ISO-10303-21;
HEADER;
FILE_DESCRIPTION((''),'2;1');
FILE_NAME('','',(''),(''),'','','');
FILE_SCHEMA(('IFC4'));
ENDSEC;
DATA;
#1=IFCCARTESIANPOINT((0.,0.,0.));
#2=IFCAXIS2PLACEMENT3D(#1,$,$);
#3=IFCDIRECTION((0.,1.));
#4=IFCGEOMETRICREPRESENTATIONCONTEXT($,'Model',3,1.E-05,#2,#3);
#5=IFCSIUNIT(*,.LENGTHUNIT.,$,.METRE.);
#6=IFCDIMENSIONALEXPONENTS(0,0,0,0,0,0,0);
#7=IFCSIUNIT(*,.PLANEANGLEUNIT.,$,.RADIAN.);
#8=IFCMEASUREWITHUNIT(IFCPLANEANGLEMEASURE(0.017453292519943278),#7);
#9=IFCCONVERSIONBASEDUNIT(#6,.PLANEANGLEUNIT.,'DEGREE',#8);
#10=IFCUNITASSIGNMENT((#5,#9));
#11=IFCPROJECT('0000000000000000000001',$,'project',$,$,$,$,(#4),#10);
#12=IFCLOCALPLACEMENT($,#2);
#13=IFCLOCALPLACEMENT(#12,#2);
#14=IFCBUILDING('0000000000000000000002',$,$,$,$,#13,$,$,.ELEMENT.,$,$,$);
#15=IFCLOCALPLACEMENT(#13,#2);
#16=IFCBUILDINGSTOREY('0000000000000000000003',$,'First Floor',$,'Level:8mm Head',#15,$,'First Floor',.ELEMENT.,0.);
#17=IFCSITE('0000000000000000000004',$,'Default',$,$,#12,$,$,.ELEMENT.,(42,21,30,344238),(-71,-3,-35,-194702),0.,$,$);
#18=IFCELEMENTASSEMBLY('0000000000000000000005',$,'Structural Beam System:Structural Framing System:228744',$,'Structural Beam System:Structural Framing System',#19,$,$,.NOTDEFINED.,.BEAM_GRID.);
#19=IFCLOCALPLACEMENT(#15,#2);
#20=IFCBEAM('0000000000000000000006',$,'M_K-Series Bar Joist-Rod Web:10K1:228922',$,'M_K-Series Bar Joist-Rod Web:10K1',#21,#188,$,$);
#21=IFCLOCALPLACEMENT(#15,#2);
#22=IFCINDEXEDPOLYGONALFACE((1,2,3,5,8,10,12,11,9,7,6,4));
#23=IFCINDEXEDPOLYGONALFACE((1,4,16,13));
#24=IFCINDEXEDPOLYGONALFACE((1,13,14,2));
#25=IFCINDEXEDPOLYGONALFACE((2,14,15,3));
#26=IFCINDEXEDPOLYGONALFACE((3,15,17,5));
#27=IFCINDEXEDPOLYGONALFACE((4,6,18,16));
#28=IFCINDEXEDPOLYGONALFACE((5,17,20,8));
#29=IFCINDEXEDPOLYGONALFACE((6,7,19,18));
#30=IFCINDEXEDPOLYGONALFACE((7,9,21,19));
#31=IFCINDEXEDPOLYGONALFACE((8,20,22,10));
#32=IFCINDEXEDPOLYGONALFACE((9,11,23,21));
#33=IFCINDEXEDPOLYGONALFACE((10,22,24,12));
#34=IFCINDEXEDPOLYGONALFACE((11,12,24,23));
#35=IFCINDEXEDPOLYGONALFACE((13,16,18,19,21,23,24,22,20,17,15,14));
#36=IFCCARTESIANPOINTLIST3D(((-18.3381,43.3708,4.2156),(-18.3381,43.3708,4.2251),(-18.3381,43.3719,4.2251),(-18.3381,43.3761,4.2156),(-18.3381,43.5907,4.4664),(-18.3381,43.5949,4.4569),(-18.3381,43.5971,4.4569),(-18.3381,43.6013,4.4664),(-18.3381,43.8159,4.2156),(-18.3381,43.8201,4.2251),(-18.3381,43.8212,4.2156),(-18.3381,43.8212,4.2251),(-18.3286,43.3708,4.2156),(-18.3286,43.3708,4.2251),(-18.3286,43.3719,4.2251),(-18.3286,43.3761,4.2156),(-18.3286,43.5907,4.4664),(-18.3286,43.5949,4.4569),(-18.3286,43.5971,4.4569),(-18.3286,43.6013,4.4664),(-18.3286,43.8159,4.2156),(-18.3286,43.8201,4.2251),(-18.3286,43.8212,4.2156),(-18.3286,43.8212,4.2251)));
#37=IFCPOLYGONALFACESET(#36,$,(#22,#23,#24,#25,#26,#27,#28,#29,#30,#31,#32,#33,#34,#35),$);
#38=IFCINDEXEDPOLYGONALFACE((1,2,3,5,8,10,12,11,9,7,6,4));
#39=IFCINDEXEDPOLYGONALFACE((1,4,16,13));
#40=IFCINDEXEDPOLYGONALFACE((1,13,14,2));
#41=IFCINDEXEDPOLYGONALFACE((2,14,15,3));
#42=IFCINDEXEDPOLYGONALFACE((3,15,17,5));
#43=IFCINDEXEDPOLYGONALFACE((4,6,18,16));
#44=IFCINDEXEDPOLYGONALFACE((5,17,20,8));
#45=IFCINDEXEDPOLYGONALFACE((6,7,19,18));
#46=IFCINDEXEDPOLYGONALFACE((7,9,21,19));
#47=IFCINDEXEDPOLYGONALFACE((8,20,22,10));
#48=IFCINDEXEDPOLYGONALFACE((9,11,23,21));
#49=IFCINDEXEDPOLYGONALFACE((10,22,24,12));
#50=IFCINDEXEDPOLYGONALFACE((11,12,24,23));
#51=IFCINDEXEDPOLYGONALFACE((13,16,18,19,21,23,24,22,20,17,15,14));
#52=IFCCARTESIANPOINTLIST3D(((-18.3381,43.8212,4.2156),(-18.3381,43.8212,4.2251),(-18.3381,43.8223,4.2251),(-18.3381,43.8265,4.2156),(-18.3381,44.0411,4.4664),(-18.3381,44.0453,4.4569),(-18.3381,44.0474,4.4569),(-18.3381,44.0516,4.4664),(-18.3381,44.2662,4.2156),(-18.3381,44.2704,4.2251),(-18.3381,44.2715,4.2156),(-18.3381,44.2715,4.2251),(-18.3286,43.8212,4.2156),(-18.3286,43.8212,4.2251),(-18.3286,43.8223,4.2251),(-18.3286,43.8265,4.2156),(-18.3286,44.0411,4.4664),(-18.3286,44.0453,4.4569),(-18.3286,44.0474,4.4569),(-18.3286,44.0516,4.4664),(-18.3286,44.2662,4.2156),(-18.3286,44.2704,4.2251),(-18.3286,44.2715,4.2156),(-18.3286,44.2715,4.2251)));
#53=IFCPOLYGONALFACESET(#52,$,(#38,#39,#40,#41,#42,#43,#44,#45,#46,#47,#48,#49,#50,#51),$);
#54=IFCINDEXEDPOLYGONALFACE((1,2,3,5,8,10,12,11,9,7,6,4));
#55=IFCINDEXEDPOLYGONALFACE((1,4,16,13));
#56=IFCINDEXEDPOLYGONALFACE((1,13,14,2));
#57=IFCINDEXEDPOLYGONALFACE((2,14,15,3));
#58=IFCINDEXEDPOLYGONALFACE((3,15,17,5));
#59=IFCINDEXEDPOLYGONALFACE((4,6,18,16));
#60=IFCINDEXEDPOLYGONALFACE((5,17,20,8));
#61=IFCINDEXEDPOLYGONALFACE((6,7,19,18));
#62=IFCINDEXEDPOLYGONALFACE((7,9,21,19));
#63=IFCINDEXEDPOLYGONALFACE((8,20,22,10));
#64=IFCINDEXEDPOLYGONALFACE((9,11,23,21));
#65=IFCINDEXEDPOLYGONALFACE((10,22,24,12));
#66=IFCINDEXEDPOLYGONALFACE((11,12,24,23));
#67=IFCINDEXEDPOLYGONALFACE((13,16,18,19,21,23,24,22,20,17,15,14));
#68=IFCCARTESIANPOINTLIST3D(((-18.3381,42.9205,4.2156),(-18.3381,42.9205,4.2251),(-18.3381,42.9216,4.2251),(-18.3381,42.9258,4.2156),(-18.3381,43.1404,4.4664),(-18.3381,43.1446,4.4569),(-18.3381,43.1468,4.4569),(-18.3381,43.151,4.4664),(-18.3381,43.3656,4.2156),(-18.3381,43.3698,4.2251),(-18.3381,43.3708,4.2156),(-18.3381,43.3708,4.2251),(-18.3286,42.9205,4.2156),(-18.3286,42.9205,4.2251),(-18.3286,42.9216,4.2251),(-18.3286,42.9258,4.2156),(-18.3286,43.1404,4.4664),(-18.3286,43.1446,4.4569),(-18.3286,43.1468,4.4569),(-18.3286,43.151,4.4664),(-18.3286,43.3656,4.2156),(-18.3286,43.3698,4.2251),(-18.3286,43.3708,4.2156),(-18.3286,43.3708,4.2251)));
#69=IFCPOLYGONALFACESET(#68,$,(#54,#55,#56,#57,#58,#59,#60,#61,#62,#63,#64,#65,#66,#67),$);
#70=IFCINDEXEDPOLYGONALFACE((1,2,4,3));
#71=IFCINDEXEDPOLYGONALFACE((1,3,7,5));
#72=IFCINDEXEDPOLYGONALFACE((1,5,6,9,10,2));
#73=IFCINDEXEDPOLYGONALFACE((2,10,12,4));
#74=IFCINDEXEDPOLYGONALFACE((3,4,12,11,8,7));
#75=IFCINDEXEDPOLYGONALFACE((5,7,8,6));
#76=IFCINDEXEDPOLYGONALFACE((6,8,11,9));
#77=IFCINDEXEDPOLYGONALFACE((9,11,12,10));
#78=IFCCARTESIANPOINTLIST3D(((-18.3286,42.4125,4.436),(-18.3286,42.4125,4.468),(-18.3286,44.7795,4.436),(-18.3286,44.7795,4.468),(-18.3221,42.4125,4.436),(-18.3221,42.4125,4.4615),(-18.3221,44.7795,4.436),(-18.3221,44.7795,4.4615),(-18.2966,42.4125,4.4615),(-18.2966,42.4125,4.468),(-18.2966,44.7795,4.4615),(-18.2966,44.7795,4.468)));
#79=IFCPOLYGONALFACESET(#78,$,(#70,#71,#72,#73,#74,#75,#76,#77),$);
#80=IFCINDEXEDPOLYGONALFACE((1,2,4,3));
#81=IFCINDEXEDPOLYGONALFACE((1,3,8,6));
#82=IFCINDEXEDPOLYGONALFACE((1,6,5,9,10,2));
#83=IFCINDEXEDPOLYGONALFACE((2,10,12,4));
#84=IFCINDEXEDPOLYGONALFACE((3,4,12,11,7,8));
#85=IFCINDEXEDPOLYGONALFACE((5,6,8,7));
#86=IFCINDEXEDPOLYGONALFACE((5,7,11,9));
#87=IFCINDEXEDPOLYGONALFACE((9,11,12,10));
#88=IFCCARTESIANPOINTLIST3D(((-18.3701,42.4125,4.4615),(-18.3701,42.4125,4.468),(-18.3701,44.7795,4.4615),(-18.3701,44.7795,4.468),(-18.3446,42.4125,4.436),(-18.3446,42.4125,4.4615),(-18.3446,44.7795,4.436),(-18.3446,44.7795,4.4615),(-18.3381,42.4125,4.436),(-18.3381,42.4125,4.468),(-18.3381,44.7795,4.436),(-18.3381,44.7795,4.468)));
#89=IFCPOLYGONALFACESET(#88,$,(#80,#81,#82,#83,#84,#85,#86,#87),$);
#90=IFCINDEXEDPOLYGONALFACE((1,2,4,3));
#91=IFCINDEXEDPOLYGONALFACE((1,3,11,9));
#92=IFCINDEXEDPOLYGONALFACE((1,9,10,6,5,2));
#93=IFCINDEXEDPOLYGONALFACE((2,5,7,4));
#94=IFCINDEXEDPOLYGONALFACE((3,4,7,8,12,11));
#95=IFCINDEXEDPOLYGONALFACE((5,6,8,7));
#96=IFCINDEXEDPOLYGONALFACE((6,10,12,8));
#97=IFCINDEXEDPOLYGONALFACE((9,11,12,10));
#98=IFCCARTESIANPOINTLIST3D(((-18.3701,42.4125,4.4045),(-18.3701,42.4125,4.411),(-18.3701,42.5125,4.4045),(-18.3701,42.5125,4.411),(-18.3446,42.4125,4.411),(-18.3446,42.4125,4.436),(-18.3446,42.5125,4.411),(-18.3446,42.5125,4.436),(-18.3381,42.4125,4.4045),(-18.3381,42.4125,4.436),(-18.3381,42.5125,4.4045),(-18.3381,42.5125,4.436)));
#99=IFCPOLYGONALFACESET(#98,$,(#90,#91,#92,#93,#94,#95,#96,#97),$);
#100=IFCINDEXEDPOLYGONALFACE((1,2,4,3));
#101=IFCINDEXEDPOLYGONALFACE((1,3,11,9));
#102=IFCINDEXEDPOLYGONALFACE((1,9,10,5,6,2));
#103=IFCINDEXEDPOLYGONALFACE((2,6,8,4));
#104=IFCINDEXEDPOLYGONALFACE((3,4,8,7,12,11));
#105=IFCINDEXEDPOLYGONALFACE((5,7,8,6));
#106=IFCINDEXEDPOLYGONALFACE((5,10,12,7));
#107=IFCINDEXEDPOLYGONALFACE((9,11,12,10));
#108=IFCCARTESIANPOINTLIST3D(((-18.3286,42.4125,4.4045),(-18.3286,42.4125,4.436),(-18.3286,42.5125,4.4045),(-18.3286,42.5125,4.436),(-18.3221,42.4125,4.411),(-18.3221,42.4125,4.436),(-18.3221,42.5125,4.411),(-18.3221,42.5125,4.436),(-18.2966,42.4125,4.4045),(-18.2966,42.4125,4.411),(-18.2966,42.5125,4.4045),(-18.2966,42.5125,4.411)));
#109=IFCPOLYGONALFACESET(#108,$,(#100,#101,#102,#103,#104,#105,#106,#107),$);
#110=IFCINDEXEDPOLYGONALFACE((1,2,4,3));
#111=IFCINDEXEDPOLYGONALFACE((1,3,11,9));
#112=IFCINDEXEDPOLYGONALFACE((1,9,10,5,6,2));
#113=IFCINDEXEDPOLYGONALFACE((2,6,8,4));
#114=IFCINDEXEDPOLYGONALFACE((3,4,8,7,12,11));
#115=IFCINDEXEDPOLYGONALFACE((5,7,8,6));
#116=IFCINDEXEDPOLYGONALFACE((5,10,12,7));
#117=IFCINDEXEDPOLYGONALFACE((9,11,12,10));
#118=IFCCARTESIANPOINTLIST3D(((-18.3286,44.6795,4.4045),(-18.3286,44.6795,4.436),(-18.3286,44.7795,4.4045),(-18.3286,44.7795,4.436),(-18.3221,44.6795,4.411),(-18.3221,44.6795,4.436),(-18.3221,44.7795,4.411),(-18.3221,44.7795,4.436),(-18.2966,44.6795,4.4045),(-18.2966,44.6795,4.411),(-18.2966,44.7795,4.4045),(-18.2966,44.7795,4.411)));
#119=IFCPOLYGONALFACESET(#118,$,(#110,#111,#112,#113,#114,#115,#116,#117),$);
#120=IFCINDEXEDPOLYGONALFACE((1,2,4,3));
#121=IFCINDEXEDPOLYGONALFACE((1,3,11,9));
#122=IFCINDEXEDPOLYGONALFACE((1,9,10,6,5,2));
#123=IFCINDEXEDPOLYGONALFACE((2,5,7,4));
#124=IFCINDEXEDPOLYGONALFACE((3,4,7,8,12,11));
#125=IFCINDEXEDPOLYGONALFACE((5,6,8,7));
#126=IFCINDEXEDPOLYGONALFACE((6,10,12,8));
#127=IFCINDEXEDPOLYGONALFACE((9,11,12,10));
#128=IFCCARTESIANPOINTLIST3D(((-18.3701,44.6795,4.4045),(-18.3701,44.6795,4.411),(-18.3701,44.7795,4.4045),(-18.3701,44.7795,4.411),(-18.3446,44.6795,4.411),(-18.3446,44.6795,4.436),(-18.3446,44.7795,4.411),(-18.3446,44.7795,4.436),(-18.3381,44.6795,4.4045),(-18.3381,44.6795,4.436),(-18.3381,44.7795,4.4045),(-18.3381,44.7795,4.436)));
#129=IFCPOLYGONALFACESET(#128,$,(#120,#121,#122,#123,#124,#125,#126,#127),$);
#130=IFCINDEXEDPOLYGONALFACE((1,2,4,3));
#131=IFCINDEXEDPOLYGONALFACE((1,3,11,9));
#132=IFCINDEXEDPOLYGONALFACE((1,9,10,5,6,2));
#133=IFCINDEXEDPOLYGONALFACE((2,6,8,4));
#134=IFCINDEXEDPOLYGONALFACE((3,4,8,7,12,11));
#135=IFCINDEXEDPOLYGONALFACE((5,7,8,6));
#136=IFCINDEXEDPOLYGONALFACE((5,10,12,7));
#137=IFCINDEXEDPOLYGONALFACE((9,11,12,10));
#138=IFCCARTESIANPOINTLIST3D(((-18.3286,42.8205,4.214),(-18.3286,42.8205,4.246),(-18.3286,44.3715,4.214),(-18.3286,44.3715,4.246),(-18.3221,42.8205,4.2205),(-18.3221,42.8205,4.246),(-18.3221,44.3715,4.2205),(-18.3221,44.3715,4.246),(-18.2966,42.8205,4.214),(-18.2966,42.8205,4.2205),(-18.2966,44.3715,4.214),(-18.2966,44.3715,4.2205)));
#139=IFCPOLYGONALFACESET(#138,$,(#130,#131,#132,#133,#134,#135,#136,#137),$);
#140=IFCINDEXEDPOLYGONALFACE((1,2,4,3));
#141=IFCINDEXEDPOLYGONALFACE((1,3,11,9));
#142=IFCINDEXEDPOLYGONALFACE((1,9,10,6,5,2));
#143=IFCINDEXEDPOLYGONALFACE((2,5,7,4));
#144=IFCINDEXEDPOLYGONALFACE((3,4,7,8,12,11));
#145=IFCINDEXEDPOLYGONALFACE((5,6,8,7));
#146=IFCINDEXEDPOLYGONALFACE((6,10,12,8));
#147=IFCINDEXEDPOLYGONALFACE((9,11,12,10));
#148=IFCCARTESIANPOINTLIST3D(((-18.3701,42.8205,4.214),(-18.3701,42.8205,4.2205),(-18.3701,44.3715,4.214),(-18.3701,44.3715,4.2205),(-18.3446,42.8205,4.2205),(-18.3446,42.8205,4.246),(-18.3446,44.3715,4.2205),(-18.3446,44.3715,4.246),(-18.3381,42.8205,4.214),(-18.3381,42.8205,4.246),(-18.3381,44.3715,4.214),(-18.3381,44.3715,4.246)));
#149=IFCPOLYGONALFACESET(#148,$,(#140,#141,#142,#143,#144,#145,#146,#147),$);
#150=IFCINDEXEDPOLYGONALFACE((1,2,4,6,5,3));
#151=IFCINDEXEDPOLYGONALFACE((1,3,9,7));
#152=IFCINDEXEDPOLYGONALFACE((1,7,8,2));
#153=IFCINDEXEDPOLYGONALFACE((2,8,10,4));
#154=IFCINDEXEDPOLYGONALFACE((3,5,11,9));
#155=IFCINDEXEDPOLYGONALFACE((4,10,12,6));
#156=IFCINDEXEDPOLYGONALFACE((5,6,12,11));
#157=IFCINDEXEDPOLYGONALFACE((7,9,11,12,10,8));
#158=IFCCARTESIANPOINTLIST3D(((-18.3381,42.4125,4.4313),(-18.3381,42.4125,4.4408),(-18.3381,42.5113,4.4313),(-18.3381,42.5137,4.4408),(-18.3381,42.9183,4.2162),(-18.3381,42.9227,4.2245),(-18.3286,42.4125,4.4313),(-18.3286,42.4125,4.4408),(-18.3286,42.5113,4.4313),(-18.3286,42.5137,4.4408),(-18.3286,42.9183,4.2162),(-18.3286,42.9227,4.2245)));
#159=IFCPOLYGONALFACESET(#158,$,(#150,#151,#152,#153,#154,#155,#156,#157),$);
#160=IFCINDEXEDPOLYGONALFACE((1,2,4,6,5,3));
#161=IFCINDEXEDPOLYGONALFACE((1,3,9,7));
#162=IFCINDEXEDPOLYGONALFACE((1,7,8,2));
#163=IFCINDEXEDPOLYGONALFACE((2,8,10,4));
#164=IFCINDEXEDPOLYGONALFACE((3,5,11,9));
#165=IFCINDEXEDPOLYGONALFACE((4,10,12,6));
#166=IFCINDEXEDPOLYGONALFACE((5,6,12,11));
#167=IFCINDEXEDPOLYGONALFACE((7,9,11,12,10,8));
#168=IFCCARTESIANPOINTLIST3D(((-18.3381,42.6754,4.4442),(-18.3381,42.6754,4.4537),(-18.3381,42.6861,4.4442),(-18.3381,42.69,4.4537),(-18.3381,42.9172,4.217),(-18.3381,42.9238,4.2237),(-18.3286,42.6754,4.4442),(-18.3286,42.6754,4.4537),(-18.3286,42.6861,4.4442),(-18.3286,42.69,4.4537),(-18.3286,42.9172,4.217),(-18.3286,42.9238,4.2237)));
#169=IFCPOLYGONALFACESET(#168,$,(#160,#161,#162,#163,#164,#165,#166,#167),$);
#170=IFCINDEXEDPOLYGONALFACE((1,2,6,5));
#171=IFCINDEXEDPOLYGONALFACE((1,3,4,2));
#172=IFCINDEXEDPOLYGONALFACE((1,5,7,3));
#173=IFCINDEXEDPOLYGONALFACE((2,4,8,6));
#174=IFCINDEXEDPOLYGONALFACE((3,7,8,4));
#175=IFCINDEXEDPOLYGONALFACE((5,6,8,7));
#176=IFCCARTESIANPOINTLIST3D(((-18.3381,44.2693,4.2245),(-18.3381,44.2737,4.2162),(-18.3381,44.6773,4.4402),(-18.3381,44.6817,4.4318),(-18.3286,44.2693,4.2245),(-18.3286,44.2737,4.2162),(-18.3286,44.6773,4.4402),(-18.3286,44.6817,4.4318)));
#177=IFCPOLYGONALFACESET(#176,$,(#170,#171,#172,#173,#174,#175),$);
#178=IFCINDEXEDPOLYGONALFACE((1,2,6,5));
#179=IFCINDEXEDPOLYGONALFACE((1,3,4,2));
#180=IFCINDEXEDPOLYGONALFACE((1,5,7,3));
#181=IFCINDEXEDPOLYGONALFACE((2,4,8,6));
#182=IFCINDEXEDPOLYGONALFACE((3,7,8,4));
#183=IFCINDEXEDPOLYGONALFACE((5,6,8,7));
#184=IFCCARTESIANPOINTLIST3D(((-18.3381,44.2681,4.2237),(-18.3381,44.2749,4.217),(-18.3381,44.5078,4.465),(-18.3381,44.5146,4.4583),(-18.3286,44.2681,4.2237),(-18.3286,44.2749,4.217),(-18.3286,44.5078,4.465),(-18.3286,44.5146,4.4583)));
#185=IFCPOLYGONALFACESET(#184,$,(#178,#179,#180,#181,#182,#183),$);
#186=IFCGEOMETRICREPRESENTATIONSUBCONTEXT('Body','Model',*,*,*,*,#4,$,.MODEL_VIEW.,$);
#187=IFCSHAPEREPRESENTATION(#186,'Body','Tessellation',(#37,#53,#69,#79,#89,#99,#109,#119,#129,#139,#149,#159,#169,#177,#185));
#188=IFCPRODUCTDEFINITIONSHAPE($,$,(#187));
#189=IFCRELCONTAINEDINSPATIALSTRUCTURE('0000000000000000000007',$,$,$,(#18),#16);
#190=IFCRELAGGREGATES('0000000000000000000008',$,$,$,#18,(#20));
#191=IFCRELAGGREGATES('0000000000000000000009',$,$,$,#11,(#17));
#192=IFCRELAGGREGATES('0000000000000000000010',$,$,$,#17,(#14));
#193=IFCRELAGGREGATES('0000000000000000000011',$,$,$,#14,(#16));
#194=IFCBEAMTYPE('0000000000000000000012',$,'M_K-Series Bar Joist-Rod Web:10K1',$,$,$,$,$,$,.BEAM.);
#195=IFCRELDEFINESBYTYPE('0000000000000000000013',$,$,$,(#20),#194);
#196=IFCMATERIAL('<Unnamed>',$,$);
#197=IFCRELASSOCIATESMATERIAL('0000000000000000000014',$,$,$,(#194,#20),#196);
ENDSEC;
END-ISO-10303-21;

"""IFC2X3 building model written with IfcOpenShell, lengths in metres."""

from ifc_helpers import new_model, entity, si_unit, converted_unit, direction, frame, frame_2d, origin, place, context, subcontext, project, spatial, polyline, rectangle, outline, extrude, source, transform, mapped, material, type_object, type_shapes, element, aggregate, save


model = new_model("IFC2X3")

# Units and contexts
model_context = context("Model", 3, precision=1e-05, world=origin(), true_north=direction((0.0, 1.0)))
body_context = subcontext(model_context, "Body", "Model", "MODEL_VIEW")
ifc_project = project(units=[si_unit("LENGTHUNIT", "METRE"), converted_unit("PLANEANGLEUNIT", "DEGREE", entity("IfcPlaneAngleMeasure", 0.017453292519943278), si_unit("PLANEANGLEUNIT", "RADIAN"), dimensions=[0, 0, 0, 0, 0, 0, 0])], contexts=[model_context])

# Site, building, storey
site_placement = place(None, origin())
site = spatial("IfcSite", under=ifc_project, at=site_placement, Name="Default", CompositionType="ELEMENT", RefLatitude=(42, 21, 30, 344238), RefLongitude=(-71, -3, -35, -194702), RefElevation=0.0)
building_placement = place(site_placement, origin())
building = spatial("IfcBuilding", under=site, at=building_placement, CompositionType="ELEMENT")
storey_placement = place(building_placement, origin())
storey = spatial("IfcBuildingStorey", under=building, at=storey_placement, Name="First Floor", ObjectType="Level:8mm Head", LongName="First Floor", CompositionType="ELEMENT", Elevation=0.0)

# Shared definitions
ifc_material_1 = material(Name="<Unnamed>")

# Element assembly, beam
assembly_1_placement = place(storey_placement, origin())
assembly_1 = element("IfcElementAssembly", 1, at=assembly_1_placement, inside=storey, Name="Structural Beam System:Structural Framing System:228744", ObjectType="Structural Beam System:Structural Framing System", AssemblyPlace="NOTDEFINED", PredefinedType="BEAM_GRID")
beam_type_1 = type_object("IfcBeamType", Name="M_K-Series Bar Joist-Rod Web:10K1", PredefinedType="BEAM", material=ifc_material_1)
shared_shape_1 = source(origin(), body_context, "Body", "SweptSolid", [
    extrude(outline(polyline([(-0.2252, -0.0757), (-0.2252, -0.0852), (-0.2199, -0.0852), (-0.0011, 0.1561), (0.0011, 0.1561), (0.2199, -0.0852), (0.2252, -0.0852), (0.2252, -0.0757), (0.2241, -0.0757), (0.0053, 0.1656), (-0.0053, 0.1656), (-0.2241, -0.0757), (-0.2252, -0.0757)])), frame((0.0, -0.0047, -0.0402), z_axis=(0.0, -1.0, 0.0), x_axis=(1.0, 0.0, 0.0)), (0.0, 0.0, -1.0), 0.0095),
    extrude(outline(polyline([(-0.2252, -0.0757), (-0.2252, -0.0852), (-0.2199, -0.0852), (-0.0011, 0.1561), (0.0011, 0.1561), (0.2199, -0.0852), (0.2252, -0.0852), (0.2252, -0.0757), (0.2241, -0.0757), (0.0053, 0.1656), (-0.0053, 0.1656), (-0.2241, -0.0757), (-0.2252, -0.0757)])), frame((0.4503, -0.0047, -0.0402), z_axis=(0.0, -1.0, 0.0), x_axis=(1.0, 0.0, 0.0)), (0.0, 0.0, -1.0), 0.0095),
    extrude(outline(polyline([(-0.2252, -0.0757), (-0.2252, -0.0852), (-0.2199, -0.0852), (-0.0011, 0.1561), (0.0011, 0.1561), (0.2199, -0.0852), (0.2252, -0.0852), (0.2252, -0.0757), (0.2241, -0.0757), (0.0053, 0.1656), (-0.0053, 0.1656), (-0.2241, -0.0757), (-0.2252, -0.0757)])), frame((-0.4503, -0.0047, -0.0402), z_axis=(0.0, -1.0, 0.0), x_axis=(1.0, 0.0, 0.0)), (0.0, 0.0, -1.0), 0.0095),
    extrude(outline(polyline([(-0.0128, -0.0128), (0.0192, -0.0128), (0.0192, -0.0063), (-0.0063, -0.0063), (-0.0063, 0.0192), (-0.0128, 0.0192), (-0.0128, -0.0128)])), frame((-1.1835, -0.0176, 0.1142), z_axis=(1.0, 0.0, 0.0), x_axis=(0.0, -1.0, 0.0)), (0.0, 0.0, 1.0), 2.367),
    extrude(outline(polyline([(-0.0128, -0.0128), (0.0192, -0.0128), (0.0192, -0.0063), (-0.0063, -0.0063), (-0.0063, 0.0192), (-0.0128, 0.0192), (-0.0128, -0.0128)])), frame((-1.1835, 0.0176, 0.1142), z_axis=(1.0, 0.0, 0.0), x_axis=(0.0, 0.0, -1.0)), (0.0, 0.0, 1.0), 2.367),
    extrude(outline(polyline([(-0.0127, -0.0192), (-0.0062, -0.0192), (-0.0062, 0.0063), (0.0188, 0.0063), (0.0188, 0.0128), (-0.0127, 0.0128), (-0.0127, -0.0192)])), frame((-1.1835, 0.0176, 0.0762), z_axis=(1.0, 0.0, 0.0), x_axis=(0.0, 0.0, 1.0)), (0.0, 0.0, 1.0), 0.1),
    extrude(outline(polyline([(-0.0127, -0.0128), (0.0188, -0.0128), (0.0188, -0.0063), (-0.0062, -0.0063), (-0.0062, 0.0192), (-0.0127, 0.0192), (-0.0127, -0.0128)])), frame((-1.1835, -0.0176, 0.0762), z_axis=(1.0, 0.0, 0.0), x_axis=(0.0, 0.0, 1.0)), (0.0, 0.0, 1.0), 0.1),
    extrude(outline(polyline([(-0.0127, -0.0128), (0.0188, -0.0128), (0.0188, -0.0063), (-0.0062, -0.0063), (-0.0062, 0.0192), (-0.0127, 0.0192), (-0.0127, -0.0128)])), frame((1.0835, -0.0176, 0.0762), z_axis=(1.0, 0.0, 0.0), x_axis=(0.0, 0.0, 1.0)), (0.0, 0.0, 1.0), 0.1),
    extrude(outline(polyline([(-0.0128, -0.0127), (0.0192, -0.0127), (0.0192, -0.0062), (-0.0063, -0.0062), (-0.0063, 0.0188), (-0.0128, 0.0188), (-0.0128, -0.0127)])), frame((1.0835, 0.0176, 0.0762), z_axis=(1.0, 0.0, 0.0), x_axis=(0.0, 1.0, 0.0)), (0.0, 0.0, 1.0), 0.1),
    extrude(outline(polyline([(-0.0128, -0.0128), (0.0192, -0.0128), (0.0192, -0.0063), (-0.0063, -0.0063), (-0.0063, 0.0192), (-0.0128, 0.0192), (-0.0128, -0.0128)])), frame((-0.7755, -0.0176, -0.1142), z_axis=(1.0, 0.0, 0.0), x_axis=(0.0, 0.0, 1.0)), (0.0, 0.0, 1.0), 1.551),
    extrude(outline(polyline([(-0.0128, -0.0128), (0.0192, -0.0128), (0.0192, -0.0063), (-0.0063, -0.0063), (-0.0063, 0.0192), (-0.0128, 0.0192), (-0.0128, -0.0128)])), frame((-0.7755, 0.0176, -0.1142), z_axis=(1.0, 0.0, 0.0), x_axis=(0.0, 1.0, 0.0)), (0.0, 0.0, 1.0), 1.551),
    extrude(outline(polyline([(-0.3371, -0.0108), (-0.3371, -0.0203), (0.1255, -0.0203), (0.215, 0.027), (0.2105, 0.0354), (0.1232, -0.0108), (-0.3371, -0.0108)])), frame((-0.9808, -0.0048, 0.0231), z_axis=(0.0, -1.0, 0.0), x_axis=(-0.884101, 0.0, 0.467295)), (0.0, 0.0, -1.0), 0.0095),
    extrude(outline(polyline([(-0.0859, -0.0809), (-0.0713, -0.0809), (0.1625, 0.149), (0.1559, 0.1558), (-0.0752, -0.0714), (-0.0859, -0.0714), (-0.0859, -0.0809)])), frame((-0.8347, -0.0047, 0.0318), z_axis=(0.0, 1.0, 0.0), x_axis=(1.0, 0.0, 0.0)), (0.0, 0.0, 1.0), 0.0095),
    extrude(rectangle(XDim=0.0095, YDim=0.0095, at=frame_2d((0.0, 0.0), x_axis=(0.0, 1.0))), frame((0.6755, 0.0, -0.1206), z_axis=(0.884101, 0.0, 0.467295), x_axis=(0.0, 1.0, 0.0)), (0.0, 0.0, 1.0), 0.4615),
    extrude(rectangle(XDim=0.3401, YDim=0.0095, at=frame_2d((0.0, 0.0), x_axis=(1.0, 0.0))), frame((0.7953, -0.0047, 0.0), z_axis=(0.0, 1.0, 0.0), x_axis=(-0.704723, 0.0, -0.709483)), (0.0, 0.0, 1.0), 0.0095),
])
type_shapes(beam_type_1, [shared_shape_1])
beam_1_placement = place(assembly_1_placement, frame((-18.3333, 43.596, 4.341), z_axis=(0.0, 0.0, 1.0), x_axis=(0.0, 1.0, 0.0)))
beam_1 = element("IfcBeam", 2, at=beam_1_placement, type_object=beam_type_1, material=ifc_material_1, Name="M_K-Series Bar Joist-Rod Web:10K1:228922", ObjectType="M_K-Series Bar Joist-Rod Web:10K1", context=body_context, shape_type="MappedRepresentation", body=[
    mapped(shared_shape_1, transform((0.0, 0.0, 0.0), scale=1.0)),
])
aggregate(assembly_1, [beam_1])

save(model, "model.ifc")
